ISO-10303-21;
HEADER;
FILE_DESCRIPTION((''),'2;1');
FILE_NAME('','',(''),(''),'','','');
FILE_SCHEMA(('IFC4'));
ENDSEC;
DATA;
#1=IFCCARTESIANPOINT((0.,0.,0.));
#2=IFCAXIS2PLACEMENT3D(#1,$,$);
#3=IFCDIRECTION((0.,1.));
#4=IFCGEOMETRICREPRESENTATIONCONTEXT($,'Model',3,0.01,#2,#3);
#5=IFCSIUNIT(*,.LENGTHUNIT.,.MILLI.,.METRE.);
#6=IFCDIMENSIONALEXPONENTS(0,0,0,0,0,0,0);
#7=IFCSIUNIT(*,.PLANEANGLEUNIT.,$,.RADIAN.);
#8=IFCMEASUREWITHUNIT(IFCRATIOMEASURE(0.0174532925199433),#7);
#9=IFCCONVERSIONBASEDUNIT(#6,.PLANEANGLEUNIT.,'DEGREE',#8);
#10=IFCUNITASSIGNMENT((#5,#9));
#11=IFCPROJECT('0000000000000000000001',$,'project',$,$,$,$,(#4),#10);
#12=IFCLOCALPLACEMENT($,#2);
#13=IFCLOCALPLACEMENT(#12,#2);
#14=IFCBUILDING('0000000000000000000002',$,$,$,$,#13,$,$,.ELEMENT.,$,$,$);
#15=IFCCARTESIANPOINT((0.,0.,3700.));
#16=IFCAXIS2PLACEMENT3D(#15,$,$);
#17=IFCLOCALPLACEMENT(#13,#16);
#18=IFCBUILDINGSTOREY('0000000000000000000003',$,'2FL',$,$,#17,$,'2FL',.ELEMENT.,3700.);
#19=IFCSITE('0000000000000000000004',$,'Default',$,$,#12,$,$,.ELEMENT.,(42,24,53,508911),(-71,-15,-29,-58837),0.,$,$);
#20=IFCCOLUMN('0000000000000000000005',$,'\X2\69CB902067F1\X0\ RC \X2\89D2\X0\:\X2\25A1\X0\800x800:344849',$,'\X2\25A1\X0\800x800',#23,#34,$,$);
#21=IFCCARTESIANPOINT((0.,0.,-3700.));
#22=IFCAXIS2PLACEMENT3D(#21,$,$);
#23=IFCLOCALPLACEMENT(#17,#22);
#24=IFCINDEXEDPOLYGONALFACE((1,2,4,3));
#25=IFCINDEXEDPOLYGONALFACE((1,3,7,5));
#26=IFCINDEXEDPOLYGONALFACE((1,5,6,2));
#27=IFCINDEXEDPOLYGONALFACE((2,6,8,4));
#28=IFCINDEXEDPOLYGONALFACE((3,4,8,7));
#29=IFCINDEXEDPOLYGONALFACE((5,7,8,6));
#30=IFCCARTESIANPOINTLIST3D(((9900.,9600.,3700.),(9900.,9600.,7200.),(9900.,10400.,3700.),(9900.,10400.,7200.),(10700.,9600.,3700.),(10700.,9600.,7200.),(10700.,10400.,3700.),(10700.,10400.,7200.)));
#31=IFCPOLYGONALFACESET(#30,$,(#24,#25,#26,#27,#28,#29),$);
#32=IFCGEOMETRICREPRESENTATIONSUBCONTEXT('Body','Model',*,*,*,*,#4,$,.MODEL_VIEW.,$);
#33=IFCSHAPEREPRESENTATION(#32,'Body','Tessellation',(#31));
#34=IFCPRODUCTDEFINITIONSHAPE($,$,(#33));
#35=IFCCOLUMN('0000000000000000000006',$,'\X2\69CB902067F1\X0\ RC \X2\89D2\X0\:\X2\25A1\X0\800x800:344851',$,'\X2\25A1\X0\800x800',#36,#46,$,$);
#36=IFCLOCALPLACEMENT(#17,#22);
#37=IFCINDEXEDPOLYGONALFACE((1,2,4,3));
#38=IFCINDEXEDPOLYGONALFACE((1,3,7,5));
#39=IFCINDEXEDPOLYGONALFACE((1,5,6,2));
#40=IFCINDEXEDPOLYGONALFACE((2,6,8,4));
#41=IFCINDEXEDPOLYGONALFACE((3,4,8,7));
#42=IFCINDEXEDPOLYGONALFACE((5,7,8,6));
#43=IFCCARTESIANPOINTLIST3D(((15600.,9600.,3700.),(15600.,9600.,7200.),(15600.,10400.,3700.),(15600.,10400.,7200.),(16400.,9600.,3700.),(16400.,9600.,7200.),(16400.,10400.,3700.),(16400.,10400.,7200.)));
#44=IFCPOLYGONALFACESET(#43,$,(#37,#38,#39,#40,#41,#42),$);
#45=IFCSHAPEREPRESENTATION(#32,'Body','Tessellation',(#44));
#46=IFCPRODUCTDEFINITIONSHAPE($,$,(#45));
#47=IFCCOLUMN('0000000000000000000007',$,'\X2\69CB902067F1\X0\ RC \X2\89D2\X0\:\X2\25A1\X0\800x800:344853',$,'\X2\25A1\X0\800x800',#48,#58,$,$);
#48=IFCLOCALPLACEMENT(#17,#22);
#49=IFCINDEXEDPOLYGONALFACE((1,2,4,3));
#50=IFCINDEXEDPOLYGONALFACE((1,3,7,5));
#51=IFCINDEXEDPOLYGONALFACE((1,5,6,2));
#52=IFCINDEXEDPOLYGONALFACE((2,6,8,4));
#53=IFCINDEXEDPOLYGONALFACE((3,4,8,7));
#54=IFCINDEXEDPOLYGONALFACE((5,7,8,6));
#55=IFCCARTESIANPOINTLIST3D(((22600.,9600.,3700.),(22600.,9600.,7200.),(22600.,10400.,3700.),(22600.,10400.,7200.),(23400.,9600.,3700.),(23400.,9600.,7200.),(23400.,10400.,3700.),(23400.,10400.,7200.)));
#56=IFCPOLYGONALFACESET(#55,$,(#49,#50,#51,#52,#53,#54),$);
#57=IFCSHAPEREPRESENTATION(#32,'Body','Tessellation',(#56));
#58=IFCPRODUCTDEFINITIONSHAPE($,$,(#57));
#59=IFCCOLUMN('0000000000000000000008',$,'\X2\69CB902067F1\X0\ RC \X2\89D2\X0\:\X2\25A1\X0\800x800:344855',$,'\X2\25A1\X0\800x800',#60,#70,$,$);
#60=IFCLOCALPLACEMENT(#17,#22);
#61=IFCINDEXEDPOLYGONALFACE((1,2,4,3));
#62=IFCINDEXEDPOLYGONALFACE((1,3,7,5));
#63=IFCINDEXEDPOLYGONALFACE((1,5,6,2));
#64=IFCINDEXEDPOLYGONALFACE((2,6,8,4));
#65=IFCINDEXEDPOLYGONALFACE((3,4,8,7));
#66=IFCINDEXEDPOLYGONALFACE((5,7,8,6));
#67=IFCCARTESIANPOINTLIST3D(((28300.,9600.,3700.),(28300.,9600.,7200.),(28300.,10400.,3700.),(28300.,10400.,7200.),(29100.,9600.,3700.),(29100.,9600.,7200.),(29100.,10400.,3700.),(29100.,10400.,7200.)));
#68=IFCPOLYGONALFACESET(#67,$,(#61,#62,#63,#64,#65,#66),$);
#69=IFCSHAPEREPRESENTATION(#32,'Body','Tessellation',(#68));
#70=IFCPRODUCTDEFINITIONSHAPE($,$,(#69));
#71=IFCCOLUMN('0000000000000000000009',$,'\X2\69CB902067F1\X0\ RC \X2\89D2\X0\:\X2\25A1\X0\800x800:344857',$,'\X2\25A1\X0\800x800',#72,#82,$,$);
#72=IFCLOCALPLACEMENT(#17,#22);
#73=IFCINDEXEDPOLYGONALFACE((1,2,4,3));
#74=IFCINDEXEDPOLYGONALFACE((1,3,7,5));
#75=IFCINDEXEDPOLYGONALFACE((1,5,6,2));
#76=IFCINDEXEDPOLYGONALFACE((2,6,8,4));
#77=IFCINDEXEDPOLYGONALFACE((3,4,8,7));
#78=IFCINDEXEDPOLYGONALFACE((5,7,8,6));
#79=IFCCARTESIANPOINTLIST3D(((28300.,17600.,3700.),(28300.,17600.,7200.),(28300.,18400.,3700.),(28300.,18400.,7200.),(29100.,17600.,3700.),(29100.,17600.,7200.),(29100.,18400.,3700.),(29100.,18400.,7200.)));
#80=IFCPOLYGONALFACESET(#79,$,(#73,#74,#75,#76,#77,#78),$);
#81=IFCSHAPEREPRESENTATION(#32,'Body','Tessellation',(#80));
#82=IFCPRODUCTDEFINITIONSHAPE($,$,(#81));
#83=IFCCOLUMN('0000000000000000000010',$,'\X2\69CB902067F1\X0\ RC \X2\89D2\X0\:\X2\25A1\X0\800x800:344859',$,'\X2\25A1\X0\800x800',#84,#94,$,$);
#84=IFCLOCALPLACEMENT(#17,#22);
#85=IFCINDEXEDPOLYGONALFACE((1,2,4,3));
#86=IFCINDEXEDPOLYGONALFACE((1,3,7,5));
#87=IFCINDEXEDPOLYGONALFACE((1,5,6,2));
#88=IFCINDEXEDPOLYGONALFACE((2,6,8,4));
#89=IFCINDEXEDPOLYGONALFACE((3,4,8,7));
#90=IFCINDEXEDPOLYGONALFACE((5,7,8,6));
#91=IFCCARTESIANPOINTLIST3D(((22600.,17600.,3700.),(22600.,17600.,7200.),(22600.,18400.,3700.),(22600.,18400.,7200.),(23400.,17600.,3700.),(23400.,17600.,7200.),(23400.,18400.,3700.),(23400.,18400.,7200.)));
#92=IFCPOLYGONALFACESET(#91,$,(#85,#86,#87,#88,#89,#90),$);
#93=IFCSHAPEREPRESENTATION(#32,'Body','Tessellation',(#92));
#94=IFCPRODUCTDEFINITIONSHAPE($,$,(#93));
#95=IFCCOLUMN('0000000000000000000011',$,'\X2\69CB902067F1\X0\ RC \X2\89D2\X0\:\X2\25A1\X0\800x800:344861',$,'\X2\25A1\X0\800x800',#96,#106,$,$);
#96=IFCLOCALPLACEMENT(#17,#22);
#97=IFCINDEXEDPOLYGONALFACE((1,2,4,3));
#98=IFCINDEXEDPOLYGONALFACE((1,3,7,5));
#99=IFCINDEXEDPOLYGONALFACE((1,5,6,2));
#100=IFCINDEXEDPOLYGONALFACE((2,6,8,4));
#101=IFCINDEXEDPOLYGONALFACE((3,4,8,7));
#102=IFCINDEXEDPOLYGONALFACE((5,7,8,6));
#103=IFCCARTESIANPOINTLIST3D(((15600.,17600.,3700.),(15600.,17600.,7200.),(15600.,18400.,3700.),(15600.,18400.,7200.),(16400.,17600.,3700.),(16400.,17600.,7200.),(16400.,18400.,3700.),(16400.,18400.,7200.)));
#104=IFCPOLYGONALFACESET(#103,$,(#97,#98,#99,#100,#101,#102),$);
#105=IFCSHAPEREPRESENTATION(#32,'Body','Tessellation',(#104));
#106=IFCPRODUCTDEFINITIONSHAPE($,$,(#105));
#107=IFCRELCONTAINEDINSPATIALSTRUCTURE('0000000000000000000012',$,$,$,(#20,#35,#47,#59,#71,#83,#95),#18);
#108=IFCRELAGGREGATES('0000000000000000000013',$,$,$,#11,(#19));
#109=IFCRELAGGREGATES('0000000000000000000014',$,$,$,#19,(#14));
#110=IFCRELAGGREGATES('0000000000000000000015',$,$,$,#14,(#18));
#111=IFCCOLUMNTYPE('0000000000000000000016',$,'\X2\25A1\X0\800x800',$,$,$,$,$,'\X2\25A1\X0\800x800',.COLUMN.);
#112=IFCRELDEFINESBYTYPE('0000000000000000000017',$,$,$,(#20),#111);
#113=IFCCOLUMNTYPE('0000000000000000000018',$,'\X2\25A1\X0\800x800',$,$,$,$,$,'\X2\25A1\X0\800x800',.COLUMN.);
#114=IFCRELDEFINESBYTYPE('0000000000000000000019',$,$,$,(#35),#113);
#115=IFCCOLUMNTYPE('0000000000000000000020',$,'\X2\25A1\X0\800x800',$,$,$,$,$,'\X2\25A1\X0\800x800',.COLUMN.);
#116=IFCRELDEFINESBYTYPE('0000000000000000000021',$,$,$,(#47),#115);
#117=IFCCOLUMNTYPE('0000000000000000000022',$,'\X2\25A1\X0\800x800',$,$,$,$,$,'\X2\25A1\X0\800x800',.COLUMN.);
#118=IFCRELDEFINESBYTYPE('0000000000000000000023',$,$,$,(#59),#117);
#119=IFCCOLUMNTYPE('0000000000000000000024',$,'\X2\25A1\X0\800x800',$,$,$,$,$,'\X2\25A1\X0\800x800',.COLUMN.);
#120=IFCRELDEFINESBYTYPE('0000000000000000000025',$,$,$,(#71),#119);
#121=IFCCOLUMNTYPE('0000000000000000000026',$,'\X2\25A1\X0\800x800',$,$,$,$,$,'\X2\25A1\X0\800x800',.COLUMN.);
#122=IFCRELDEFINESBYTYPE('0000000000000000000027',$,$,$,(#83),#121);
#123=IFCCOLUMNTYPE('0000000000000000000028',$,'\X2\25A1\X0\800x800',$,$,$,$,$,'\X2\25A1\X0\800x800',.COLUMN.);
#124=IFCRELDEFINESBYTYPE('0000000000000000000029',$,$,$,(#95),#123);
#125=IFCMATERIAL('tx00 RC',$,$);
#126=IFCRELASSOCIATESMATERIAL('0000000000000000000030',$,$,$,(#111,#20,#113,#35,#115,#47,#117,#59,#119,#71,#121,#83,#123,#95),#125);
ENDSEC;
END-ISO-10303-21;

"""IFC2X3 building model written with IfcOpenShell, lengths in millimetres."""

from ifc_helpers import new_model, entity, si_unit, converted_unit, direction, frame, frame_2d, origin, origin_2d_with_axis, place, context, subcontext, project, spatial, rectangle, extrude, source, transform, mapped, material, type_object, type_shapes, element, save


model = new_model("IFC2X3")

# Units and contexts
model_context = context("Model", 3, precision=0.01, world=origin(), true_north=direction((0.0, 1.0)))
body_context = subcontext(model_context, "Body", "Model", "MODEL_VIEW")
ifc_project = project(units=[si_unit("LENGTHUNIT", "METRE", prefix="MILLI"), converted_unit("PLANEANGLEUNIT", "DEGREE", entity("IfcRatioMeasure", 0.0174532925199433), si_unit("PLANEANGLEUNIT", "RADIAN"), dimensions=[0, 0, 0, 0, 0, 0, 0])], contexts=[model_context])

# Site, building, storey
site_placement = place(None, origin())
site = spatial("IfcSite", under=ifc_project, at=site_placement, Name="Default", CompositionType="ELEMENT", RefLatitude=(42, 24, 53, 508911), RefLongitude=(-71, -15, -29, -58837), RefElevation=0.0)
building_placement = place(site_placement, origin())
building = spatial("IfcBuilding", under=site, at=building_placement, CompositionType="ELEMENT")
storey_placement = place(building_placement, frame((0.0, 0.0, 3700.0)))
storey = spatial("IfcBuildingStorey", under=building, at=storey_placement, Name="2FL", LongName="2FL", CompositionType="ELEMENT", Elevation=3700.0)

# Columns
ifc_material_1 = material(Name="tx00 RC")
column_type_1 = type_object("IfcColumnType", Name="□800x800", ElementType="□800x800", PredefinedType="COLUMN", material=ifc_material_1)
shared_shape_1 = source(origin(), body_context, "Body", "SweptSolid", [
    extrude(rectangle(XDim=800.0, YDim=800.0, at=frame_2d((0.0, 0.0), x_axis=(1.0, 0.0))), frame((10300.0, 10000.0, 3700.0), z_axis=(0.0, 0.0, 1.0), x_axis=(0.0, -1.0, 0.0)), (0.0, 0.0, 1.0), 3500.0),
])
type_shapes(column_type_1, [shared_shape_1])
column_1_placement = place(storey_placement, frame((0.0, 0.0, -3700.0)))
element("IfcColumn", 1, at=column_1_placement, inside=storey, type_object=column_type_1, material=ifc_material_1, Name="構造柱 RC 角:□800x800:344849", ObjectType="□800x800", context=body_context, shape_type="MappedRepresentation", body=[
    mapped(shared_shape_1, transform((0.0, 0.0, 0.0), scale=1.0)),
])
column_type_2 = type_object("IfcColumnType", Name="□800x800", ElementType="□800x800", PredefinedType="COLUMN", material=ifc_material_1)
shared_shape_2 = source(origin(), body_context, "Body", "SweptSolid", [
    extrude(rectangle(XDim=800.0, YDim=800.0, at=frame_2d((0.0, 0.0), x_axis=(1.0, 0.0))), frame((16000.0, 10000.0, 3700.0), z_axis=(0.0, 0.0, 1.0), x_axis=(0.0, -1.0, 0.0)), (0.0, 0.0, 1.0), 3500.0),
])
type_shapes(column_type_2, [shared_shape_2])
column_2_placement = place(storey_placement, frame((0.0, 0.0, -3700.0)))
element("IfcColumn", 2, at=column_2_placement, inside=storey, type_object=column_type_2, material=ifc_material_1, Name="構造柱 RC 角:□800x800:344851", ObjectType="□800x800", context=body_context, shape_type="MappedRepresentation", body=[
    mapped(shared_shape_2, transform((0.0, 0.0, 0.0), scale=1.0)),
])
column_type_3 = type_object("IfcColumnType", Name="□800x800", ElementType="□800x800", PredefinedType="COLUMN", material=ifc_material_1)
shared_shape_3 = source(origin(), body_context, "Body", "SweptSolid", [
    extrude(rectangle(XDim=800.0, YDim=800.0, at=origin_2d_with_axis()), frame((23000.0, 10000.0, 3700.0), z_axis=(0.0, 0.0, 1.0), x_axis=(0.0, -1.0, 0.0)), (0.0, 0.0, 1.0), 3500.0),
])
type_shapes(column_type_3, [shared_shape_3])
column_3_placement = place(storey_placement, frame((0.0, 0.0, -3700.0)))
element("IfcColumn", 3, at=column_3_placement, inside=storey, type_object=column_type_3, material=ifc_material_1, Name="構造柱 RC 角:□800x800:344853", ObjectType="□800x800", context=body_context, shape_type="MappedRepresentation", body=[
    mapped(shared_shape_3, transform((0.0, 0.0, 0.0), scale=1.0)),
])
column_type_4 = type_object("IfcColumnType", Name="□800x800", ElementType="□800x800", PredefinedType="COLUMN", material=ifc_material_1)
shared_shape_4 = source(origin(), body_context, "Body", "SweptSolid", [
    extrude(rectangle(XDim=800.0, YDim=800.0, at=origin_2d_with_axis()), frame((28700.0, 10000.0, 3700.0), z_axis=(0.0, 0.0, 1.0), x_axis=(0.0, -1.0, 0.0)), (0.0, 0.0, 1.0), 3500.0),
])
type_shapes(column_type_4, [shared_shape_4])
column_4_placement = place(storey_placement, frame((0.0, 0.0, -3700.0)))
element("IfcColumn", 4, at=column_4_placement, inside=storey, type_object=column_type_4, material=ifc_material_1, Name="構造柱 RC 角:□800x800:344855", ObjectType="□800x800", context=body_context, shape_type="MappedRepresentation", body=[
    mapped(shared_shape_4, transform((0.0, 0.0, 0.0), scale=1.0)),
])
column_type_5 = type_object("IfcColumnType", Name="□800x800", ElementType="□800x800", PredefinedType="COLUMN", material=ifc_material_1)
shared_shape_5 = source(origin(), body_context, "Body", "SweptSolid", [
    extrude(rectangle(XDim=800.0, YDim=800.0, at=origin_2d_with_axis()), frame((28700.0, 18000.0, 3700.0), z_axis=(0.0, 0.0, 1.0), x_axis=(0.0, -1.0, 0.0)), (0.0, 0.0, 1.0), 3500.0),
])
type_shapes(column_type_5, [shared_shape_5])
column_5_placement = place(storey_placement, frame((0.0, 0.0, -3700.0)))
element("IfcColumn", 5, at=column_5_placement, inside=storey, type_object=column_type_5, material=ifc_material_1, Name="構造柱 RC 角:□800x800:344857", ObjectType="□800x800", context=body_context, shape_type="MappedRepresentation", body=[
    mapped(shared_shape_5, transform((0.0, 0.0, 0.0), scale=1.0)),
])
column_type_6 = type_object("IfcColumnType", Name="□800x800", ElementType="□800x800", PredefinedType="COLUMN", material=ifc_material_1)
shared_shape_6 = source(origin(), body_context, "Body", "SweptSolid", [
    extrude(rectangle(XDim=800.0, YDim=800.0, at=origin_2d_with_axis()), frame((23000.0, 18000.0, 3700.0), z_axis=(0.0, 0.0, 1.0), x_axis=(0.0, -1.0, 0.0)), (0.0, 0.0, 1.0), 3500.0),
])
type_shapes(column_type_6, [shared_shape_6])
column_6_placement = place(storey_placement, frame((0.0, 0.0, -3700.0)))
element("IfcColumn", 6, at=column_6_placement, inside=storey, type_object=column_type_6, material=ifc_material_1, Name="構造柱 RC 角:□800x800:344859", ObjectType="□800x800", context=body_context, shape_type="MappedRepresentation", body=[
    mapped(shared_shape_6, transform((0.0, 0.0, 0.0), scale=1.0)),
])
column_type_7 = type_object("IfcColumnType", Name="□800x800", ElementType="□800x800", PredefinedType="COLUMN", material=ifc_material_1)
shared_shape_7 = source(origin(), body_context, "Body", "SweptSolid", [
    extrude(rectangle(XDim=800.0, YDim=800.0, at=frame_2d((0.0, 0.0), x_axis=(1.0, 0.0))), frame((16000.0, 18000.0, 3700.0), z_axis=(0.0, 0.0, 1.0), x_axis=(0.0, -1.0, 0.0)), (0.0, 0.0, 1.0), 3500.0),
])
type_shapes(column_type_7, [shared_shape_7])
column_7_placement = place(storey_placement, frame((0.0, 0.0, -3700.0)))
element("IfcColumn", 7, at=column_7_placement, inside=storey, type_object=column_type_7, material=ifc_material_1, Name="構造柱 RC 角:□800x800:344861", ObjectType="□800x800", context=body_context, shape_type="MappedRepresentation", body=[
    mapped(shared_shape_7, transform((0.0, 0.0, 0.0), scale=1.0)),
])

save(model, "model.ifc")
